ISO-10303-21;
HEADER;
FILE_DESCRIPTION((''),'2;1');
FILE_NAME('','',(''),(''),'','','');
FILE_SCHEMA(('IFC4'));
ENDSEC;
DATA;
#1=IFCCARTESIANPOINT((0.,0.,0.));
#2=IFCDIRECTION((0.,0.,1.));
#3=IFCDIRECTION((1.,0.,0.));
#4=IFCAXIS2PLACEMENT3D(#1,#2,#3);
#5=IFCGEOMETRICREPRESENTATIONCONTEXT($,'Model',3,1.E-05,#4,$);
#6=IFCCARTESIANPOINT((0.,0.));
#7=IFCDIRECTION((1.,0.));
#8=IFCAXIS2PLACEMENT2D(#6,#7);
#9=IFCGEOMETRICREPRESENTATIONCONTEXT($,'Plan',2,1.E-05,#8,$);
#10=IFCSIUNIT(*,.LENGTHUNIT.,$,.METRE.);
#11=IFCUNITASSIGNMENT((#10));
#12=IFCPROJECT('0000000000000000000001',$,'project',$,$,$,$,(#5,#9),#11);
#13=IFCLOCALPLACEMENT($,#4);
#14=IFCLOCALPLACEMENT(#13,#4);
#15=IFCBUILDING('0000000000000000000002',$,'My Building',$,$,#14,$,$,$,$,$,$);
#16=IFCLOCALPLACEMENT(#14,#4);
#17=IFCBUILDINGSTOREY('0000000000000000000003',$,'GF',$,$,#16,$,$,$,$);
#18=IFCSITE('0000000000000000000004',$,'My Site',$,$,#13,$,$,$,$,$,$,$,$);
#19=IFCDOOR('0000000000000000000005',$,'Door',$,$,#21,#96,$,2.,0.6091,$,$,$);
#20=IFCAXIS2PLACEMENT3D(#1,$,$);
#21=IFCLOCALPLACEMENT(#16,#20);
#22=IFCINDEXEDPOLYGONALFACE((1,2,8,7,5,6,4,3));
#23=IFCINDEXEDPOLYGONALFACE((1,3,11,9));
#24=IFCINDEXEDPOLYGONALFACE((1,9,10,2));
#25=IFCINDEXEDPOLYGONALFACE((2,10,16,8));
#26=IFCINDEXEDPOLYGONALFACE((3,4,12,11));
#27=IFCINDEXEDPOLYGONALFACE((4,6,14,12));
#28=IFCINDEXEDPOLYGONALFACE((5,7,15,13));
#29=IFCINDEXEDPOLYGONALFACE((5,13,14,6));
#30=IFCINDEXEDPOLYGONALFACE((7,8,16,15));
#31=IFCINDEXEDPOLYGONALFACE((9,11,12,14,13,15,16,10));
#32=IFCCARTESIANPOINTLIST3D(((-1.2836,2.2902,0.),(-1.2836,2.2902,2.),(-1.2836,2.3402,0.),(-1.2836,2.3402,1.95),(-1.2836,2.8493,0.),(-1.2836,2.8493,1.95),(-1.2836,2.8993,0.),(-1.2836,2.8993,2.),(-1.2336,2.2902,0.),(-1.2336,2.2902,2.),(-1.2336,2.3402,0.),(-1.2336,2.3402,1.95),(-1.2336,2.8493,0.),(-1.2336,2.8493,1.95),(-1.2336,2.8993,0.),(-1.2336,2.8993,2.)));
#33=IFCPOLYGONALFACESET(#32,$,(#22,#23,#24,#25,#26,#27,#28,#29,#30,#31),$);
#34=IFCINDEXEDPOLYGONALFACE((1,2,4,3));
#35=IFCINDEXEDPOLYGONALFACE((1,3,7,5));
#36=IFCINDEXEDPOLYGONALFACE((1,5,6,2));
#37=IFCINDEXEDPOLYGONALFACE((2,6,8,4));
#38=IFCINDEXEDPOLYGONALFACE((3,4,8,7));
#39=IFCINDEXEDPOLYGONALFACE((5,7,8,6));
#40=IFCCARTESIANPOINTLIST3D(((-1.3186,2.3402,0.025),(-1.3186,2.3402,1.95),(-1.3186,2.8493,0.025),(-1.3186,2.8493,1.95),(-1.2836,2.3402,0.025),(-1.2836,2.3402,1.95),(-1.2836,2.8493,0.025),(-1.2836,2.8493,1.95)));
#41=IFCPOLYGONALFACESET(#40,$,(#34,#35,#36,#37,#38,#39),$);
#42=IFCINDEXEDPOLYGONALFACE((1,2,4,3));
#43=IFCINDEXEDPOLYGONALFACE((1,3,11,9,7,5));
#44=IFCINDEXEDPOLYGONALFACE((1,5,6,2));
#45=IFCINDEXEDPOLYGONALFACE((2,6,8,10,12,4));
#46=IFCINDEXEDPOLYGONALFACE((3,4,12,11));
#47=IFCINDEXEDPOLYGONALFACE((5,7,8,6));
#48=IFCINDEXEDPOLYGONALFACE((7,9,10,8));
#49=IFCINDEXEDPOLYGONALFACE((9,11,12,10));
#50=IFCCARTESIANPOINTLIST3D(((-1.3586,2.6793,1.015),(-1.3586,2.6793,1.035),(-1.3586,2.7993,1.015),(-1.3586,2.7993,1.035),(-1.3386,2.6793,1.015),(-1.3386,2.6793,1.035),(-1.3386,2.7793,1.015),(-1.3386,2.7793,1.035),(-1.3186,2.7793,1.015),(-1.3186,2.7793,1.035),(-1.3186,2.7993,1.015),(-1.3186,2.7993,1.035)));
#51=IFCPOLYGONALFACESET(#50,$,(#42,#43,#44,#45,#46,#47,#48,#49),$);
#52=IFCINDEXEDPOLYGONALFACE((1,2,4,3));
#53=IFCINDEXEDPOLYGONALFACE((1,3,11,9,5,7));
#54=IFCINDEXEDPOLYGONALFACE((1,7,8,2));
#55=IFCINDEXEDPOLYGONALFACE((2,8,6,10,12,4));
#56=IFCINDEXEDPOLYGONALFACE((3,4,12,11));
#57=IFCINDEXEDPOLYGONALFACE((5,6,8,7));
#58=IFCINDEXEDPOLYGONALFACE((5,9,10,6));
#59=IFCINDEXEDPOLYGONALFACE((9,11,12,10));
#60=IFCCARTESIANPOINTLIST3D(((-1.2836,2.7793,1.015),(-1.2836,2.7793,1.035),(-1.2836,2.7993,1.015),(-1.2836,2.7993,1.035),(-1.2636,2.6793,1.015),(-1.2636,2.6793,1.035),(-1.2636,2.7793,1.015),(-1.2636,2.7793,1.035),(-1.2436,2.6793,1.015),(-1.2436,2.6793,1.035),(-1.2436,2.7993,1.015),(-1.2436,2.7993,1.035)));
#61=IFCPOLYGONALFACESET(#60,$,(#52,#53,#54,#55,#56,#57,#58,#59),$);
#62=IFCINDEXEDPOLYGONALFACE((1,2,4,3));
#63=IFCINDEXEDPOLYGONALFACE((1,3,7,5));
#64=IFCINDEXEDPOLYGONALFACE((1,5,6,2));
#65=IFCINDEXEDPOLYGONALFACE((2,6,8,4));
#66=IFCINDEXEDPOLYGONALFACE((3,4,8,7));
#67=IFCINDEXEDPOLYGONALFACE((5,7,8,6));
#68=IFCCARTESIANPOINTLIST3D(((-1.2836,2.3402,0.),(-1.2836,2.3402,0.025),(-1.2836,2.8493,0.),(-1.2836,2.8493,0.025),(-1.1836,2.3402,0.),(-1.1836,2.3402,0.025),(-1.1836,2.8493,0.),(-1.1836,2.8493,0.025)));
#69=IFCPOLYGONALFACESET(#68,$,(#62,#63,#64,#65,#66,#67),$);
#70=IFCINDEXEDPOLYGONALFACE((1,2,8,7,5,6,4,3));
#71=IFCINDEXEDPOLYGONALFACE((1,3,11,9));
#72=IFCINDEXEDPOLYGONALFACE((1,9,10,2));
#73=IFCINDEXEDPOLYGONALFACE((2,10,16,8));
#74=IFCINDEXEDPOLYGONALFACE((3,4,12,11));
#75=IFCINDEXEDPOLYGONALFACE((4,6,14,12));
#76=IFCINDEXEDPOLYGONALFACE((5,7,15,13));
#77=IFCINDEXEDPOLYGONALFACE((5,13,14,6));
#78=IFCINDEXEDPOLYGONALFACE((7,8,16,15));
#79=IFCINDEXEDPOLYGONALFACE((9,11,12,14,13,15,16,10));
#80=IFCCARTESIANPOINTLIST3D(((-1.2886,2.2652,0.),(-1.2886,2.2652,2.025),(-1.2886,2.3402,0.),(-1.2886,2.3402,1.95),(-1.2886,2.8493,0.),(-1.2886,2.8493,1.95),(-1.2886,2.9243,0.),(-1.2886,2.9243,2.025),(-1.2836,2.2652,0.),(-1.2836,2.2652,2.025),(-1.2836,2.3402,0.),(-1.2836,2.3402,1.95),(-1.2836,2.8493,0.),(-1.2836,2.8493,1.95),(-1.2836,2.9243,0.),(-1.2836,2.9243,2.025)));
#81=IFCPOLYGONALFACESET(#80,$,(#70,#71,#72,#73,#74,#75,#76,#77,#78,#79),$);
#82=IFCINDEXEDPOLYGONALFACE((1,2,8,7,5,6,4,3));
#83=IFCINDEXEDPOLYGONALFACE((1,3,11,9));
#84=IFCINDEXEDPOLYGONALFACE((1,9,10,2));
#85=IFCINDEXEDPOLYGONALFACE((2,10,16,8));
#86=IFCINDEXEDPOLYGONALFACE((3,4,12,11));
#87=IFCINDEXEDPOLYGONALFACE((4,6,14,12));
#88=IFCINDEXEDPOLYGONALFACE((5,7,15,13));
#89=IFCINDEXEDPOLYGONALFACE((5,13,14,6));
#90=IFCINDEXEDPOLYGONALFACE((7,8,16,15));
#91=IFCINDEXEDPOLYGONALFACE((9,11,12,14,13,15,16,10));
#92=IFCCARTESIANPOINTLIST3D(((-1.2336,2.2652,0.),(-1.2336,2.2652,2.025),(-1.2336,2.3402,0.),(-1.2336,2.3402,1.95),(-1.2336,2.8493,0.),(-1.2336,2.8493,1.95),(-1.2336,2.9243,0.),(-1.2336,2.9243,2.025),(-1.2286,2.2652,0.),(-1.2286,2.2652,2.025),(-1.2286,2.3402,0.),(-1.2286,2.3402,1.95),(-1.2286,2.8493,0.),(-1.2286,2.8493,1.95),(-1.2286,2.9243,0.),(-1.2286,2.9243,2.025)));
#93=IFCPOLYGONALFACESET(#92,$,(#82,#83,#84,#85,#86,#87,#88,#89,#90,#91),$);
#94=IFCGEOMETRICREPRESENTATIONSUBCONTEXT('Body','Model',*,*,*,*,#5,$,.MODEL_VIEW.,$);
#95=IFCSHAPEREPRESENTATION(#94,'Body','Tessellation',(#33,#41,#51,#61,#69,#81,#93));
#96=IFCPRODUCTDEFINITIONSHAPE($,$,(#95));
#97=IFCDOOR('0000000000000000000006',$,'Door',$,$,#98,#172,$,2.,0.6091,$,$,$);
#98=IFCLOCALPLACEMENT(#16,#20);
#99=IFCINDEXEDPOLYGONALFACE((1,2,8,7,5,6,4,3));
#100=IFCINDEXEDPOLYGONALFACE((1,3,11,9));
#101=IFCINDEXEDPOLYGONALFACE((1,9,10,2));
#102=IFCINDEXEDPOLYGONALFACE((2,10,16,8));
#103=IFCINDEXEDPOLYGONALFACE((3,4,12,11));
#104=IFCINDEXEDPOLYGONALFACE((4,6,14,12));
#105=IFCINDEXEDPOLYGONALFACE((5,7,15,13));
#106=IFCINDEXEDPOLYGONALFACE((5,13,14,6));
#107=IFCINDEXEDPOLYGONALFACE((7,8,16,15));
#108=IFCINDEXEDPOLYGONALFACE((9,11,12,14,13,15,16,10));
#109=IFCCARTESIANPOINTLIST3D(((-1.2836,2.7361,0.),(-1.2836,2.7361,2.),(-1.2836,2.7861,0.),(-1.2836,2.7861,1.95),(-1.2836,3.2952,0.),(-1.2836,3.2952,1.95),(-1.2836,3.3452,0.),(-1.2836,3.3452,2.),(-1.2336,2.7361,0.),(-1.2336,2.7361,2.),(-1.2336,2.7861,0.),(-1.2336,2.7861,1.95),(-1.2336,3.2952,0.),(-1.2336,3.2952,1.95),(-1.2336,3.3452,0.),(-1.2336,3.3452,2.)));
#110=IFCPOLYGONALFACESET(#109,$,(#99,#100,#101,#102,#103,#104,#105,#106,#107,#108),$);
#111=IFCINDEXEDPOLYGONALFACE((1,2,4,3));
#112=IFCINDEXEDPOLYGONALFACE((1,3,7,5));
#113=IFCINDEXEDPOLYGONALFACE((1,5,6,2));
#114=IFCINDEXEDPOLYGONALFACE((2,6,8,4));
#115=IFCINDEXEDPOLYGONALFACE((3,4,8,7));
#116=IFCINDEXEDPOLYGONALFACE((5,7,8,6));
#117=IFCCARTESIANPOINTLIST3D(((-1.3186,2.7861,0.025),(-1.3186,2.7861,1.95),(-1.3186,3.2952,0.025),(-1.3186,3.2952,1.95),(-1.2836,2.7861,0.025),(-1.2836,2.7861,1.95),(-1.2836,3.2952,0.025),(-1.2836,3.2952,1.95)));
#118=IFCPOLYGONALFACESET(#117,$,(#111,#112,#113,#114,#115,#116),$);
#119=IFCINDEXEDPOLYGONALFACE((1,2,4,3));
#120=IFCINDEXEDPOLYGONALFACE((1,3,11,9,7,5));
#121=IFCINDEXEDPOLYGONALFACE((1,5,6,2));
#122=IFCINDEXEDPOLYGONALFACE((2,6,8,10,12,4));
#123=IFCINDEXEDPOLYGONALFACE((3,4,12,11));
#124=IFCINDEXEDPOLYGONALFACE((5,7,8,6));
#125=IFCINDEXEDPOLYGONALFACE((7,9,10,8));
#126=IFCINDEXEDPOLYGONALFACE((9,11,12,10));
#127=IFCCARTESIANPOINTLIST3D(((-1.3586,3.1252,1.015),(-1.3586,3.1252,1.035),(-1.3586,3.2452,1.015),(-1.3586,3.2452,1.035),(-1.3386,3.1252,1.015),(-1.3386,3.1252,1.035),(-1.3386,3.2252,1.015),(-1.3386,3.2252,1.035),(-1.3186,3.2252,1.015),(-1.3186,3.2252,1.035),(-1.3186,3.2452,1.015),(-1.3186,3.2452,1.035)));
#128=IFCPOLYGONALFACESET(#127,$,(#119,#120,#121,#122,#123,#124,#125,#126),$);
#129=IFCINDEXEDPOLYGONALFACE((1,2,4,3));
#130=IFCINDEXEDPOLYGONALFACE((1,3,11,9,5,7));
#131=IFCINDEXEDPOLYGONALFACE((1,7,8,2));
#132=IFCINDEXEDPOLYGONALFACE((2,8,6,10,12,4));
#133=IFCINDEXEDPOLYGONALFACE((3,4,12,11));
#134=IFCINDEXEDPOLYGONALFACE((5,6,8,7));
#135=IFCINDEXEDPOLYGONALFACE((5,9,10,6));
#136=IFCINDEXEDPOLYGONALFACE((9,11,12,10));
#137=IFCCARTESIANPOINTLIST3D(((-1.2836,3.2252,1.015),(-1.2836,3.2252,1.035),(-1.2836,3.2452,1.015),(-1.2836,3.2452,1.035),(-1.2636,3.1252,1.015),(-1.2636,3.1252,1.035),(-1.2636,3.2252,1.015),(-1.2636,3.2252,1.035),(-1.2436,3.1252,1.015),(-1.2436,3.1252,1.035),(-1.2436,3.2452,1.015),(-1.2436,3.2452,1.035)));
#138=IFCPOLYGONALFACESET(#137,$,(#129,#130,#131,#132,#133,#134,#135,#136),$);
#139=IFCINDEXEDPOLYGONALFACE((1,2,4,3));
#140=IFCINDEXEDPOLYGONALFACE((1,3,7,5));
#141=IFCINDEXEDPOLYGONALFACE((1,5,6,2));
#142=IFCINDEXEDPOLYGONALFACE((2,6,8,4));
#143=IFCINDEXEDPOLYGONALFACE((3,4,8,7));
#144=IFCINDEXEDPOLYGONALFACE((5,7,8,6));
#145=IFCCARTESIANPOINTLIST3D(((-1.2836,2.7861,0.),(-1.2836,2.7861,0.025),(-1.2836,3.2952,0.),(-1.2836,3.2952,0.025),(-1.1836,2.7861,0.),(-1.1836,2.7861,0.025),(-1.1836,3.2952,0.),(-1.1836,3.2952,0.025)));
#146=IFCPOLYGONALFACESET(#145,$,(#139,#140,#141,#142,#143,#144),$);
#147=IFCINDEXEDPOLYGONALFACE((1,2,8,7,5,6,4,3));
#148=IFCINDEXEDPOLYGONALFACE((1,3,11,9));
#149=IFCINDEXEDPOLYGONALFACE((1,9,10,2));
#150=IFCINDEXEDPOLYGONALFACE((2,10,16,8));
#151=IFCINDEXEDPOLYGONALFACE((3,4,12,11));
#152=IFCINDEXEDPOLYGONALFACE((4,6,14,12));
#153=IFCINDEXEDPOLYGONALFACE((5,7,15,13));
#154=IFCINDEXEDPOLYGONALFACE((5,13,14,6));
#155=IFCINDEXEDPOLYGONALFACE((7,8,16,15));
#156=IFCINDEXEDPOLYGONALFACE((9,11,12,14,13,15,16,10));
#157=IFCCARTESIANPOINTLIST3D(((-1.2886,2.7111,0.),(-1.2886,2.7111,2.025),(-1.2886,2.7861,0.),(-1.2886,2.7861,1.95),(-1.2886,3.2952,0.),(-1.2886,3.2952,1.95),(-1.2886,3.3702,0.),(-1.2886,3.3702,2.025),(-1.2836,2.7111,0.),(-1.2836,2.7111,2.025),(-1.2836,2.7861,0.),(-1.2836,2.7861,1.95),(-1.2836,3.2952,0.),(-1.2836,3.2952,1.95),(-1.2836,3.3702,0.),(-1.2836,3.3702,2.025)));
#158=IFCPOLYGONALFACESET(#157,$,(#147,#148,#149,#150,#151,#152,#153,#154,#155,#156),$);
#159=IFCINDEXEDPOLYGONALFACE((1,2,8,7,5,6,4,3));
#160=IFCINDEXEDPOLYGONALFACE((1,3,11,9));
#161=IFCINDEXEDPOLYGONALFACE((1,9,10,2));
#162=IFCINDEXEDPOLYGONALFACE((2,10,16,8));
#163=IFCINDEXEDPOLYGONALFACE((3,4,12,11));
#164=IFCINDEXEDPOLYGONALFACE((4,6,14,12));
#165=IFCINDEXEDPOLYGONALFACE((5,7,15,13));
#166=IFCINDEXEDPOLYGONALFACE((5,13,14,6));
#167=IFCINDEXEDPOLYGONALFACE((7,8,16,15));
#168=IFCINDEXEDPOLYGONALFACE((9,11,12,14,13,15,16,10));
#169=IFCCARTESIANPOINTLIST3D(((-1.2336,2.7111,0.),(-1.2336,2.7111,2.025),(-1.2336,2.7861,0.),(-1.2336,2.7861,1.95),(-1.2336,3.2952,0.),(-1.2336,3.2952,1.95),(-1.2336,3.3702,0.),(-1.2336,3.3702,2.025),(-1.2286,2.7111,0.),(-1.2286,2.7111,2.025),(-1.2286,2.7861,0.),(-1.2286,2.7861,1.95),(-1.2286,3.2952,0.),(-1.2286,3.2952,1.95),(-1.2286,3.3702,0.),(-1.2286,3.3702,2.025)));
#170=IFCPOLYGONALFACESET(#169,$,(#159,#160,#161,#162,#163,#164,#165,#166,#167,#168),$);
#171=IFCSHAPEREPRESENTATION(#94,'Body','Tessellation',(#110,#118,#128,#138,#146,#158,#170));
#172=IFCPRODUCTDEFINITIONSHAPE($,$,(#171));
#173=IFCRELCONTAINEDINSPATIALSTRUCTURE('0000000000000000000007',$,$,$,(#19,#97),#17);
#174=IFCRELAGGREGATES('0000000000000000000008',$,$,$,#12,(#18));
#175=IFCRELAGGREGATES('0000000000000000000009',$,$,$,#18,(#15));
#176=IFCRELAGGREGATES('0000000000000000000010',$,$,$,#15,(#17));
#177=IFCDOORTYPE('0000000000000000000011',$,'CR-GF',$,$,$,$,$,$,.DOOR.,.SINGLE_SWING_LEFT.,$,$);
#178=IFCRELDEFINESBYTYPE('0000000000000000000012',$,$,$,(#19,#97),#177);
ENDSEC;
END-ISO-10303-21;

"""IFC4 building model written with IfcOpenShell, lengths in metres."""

from ifc_helpers import new_model, entity, si_unit, frame, origin_with_axes, origin_2d_with_axis, place, context, subcontext, project, spatial, line, indexed_curve, outline, extrude, shape, source, transform, mapped, type_object, type_shapes, element, save


model = new_model("IFC4")

# Units and contexts
model_context = context("Model", 3, precision=1e-05, world=origin_with_axes())
plan_context = context("Plan", 2, precision=1e-05, world=origin_2d_with_axis())
body_context_1 = subcontext(model_context, "Body", "Model", "MODEL_VIEW")
body_context_2 = subcontext(plan_context, "Body", "Plan", "PLAN_VIEW")
ifc_project = project(units=[si_unit("LENGTHUNIT", "METRE")], contexts=[model_context, plan_context])

# Site, building, storey
site_placement = place(None, origin_with_axes())
site = spatial("IfcSite", under=ifc_project, at=site_placement, Name="My Site")
building_placement = place(site_placement, origin_with_axes())
building = spatial("IfcBuilding", under=site, at=building_placement, Name="My Building")
storey_placement = place(building_placement, origin_with_axes())
storey = spatial("IfcBuildingStorey", under=building, at=storey_placement, Name="GF")

# Shared definitions
wall_1_placement = place(storey_placement, frame((-1.1836, 2.64, 0.0), z_axis=(0.0, 0.0, 1.0), x_axis=(0.0, 1.0, 0.0)))
door_type_1 = type_object("IfcDoorType", Name="CR-GF", OperationType="SINGLE_SWING_LEFT", PredefinedType="DOOR")
shared_shape_1 = source(origin_with_axes(), body_context_1, "Body", "SweptSolid", [
    extrude(outline(indexed_curve([(0.0, 0.0), (0.0, 2.0), (0.6091, 2.0), (0.6091, 0.0), (0.5591, 0.0), (0.5591, 1.95), (0.05, 1.95), (0.05, 0.0)], segments=[line(1, 2, 3, 4, 5, 6, 7, 8, 1)])), frame((0.0, 0.0, 0.0), z_axis=(0.0, -1.0, 0.0), x_axis=(1.0, 0.0, 0.0)), (0.0, 0.0, -1.0), 0.05),
    extrude(outline(indexed_curve([(0.0, 0.0), (0.5091, 0.0), (0.5091, 0.035), (0.0, 0.035)], segments=[line(1, 2, 3, 4, 1)])), frame((0.05, -0.035, 0.025), z_axis=(0.0, 0.0, 1.0), x_axis=(1.0, 0.0, 0.0)), (0.0, 0.0, 1.0), 1.925),
    extrude(outline(indexed_curve([(0.0, 0.0), (0.0, -0.04), (0.12, -0.04), (0.12, -0.02), (0.02, -0.02), (0.02, 0.0)], segments=[line(1, 2, 3, 4, 5, 6, 1)])), frame((0.1, -0.035, 1.015), z_axis=(0.0, 0.0, 1.0), x_axis=(1.0, 0.0, 0.0)), (0.0, 0.0, 1.0), 0.02),
    extrude(outline(indexed_curve([(0.0, 0.0), (0.0, 0.04), (0.12, 0.04), (0.12, 0.02), (0.02, 0.02), (0.02, 0.0)], segments=[line(1, 2, 3, 4, 5, 6, 1)])), frame((0.1, 0.0, 1.015), z_axis=(0.0, 0.0, 1.0), x_axis=(1.0, 0.0, 0.0)), (0.0, 0.0, 1.0), 0.02),
    extrude(outline(indexed_curve([(0.0, 0.0), (0.5091, 0.0), (0.5091, 0.1), (0.0, 0.1)], segments=[line(1, 2, 3, 4, 1)])), frame((0.05, 0.0, 0.0), z_axis=(0.0, 0.0, 1.0), x_axis=(1.0, 0.0, 0.0)), (0.0, 0.0, 1.0), 0.025),
    extrude(outline(indexed_curve([(0.0, 0.0), (0.0, 2.025), (0.6591, 2.025), (0.6591, 0.0), (0.5841, 0.0), (0.5841, 1.95), (0.075, 1.95), (0.075, 0.0)], segments=[line(1, 2, 3, 4, 5, 6, 7, 8, 1)])), frame((-0.025, -0.005, 0.0), z_axis=(0.0, -1.0, 0.0), x_axis=(1.0, 0.0, 0.0)), (0.0, 0.0, -1.0), 0.005),
    extrude(outline(indexed_curve([(0.0, 0.0), (0.0, 2.025), (0.6591, 2.025), (0.6591, 0.0), (0.5841, 0.0), (0.5841, 1.95), (0.075, 1.95), (0.075, 0.0)], segments=[line(1, 2, 3, 4, 5, 6, 7, 8, 1)])), frame((-0.025, 0.05, 0.0), z_axis=(0.0, -1.0, 0.0), x_axis=(1.0, 0.0, 0.0)), (0.0, 0.0, -1.0), 0.005),
])
shared_shape_2 = source(origin_with_axes(), body_context_2, "Body", "Curve2D", [
    entity("IfcIndexedPolyCurve", entity("IfcCartesianPointList2D", [[0.0, 0.0], [0.05, 0.0], [0.05, 0.05], [0.0, 0.05]]), [entity("IfcLineIndex", [1, 2, 3, 4, 1])]),
    entity("IfcIndexedPolyCurve", entity("IfcCartesianPointList2D", [[0.6091, 0.0], [0.5591, 0.0], [0.5591, 0.05], [0.6091, 0.05]]), [entity("IfcLineIndex", [1, 2, 3, 4, 1])]),
    entity("IfcIndexedPolyCurve", entity("IfcCartesianPointList2D", [[0.8137, -0.035], [0.3046, -0.035], [0.3046, 0.0], [0.8137, 0.0]]), [entity("IfcLineIndex", [1, 2, 3, 4, 1])]),
])
type_shapes(door_type_1, [shared_shape_1, shared_shape_2])

# Doors
placement_1 = place(wall_1_placement, frame((0.2593, 0.1, 0.0), z_axis=(0.0, 0.0, 1.0), x_axis=(-1.0, 0.0, 0.0)))
door_1_placement = place(placement_1, frame((0.0, 0.0, 0.0), z_axis=(0.0, 0.0, 1.0), x_axis=(1.0, 0.0, 0.0)))
element("IfcDoor", 1, at=door_1_placement, inside=storey, type_object=door_type_1, Name="Door", OverallHeight=2.0, OverallWidth=0.6091, shapes=[
    shape(body_context_1, "Body", "MappedRepresentation", [mapped(shared_shape_1, transform((0.0, 0.0, 0.0), x_axis=(1.0, 0.0, 0.0), y_axis=(0.0, 1.0, 0.0), z_axis=(0.0, 0.0, 1.0), scale=1.0))]),
    shape(body_context_2, "Body", "MappedRepresentation", [mapped(shared_shape_2, transform((0.0, 0.0, 0.0), x_axis=(1.0, 0.0, 0.0), y_axis=(0.0, 1.0, 0.0), z_axis=(0.0, 0.0, 1.0), scale=1.0))]),
])
placement_2 = place(wall_1_placement, frame((0.7052, 0.1, 0.0), z_axis=(0.0, 0.0, 1.0), x_axis=(-1.0, 0.0, 0.0)))
door_2_placement = place(placement_2, frame((0.0, 0.0, 0.0), z_axis=(0.0, 0.0, 1.0), x_axis=(1.0, 0.0, 0.0)))
element("IfcDoor", 2, at=door_2_placement, inside=storey, type_object=door_type_1, Name="Door", OverallHeight=2.0, OverallWidth=0.6091, shapes=[
    shape(body_context_1, "Body", "MappedRepresentation", [mapped(shared_shape_1, transform((0.0, 0.0, 0.0), x_axis=(1.0, 0.0, 0.0), y_axis=(0.0, 1.0, 0.0), z_axis=(0.0, 0.0, 1.0), scale=1.0))]),
    shape(body_context_2, "Body", "MappedRepresentation", [mapped(shared_shape_2, transform((0.0, 0.0, 0.0), x_axis=(1.0, 0.0, 0.0), y_axis=(0.0, 1.0, 0.0), z_axis=(0.0, 0.0, 1.0), scale=1.0))]),
])

save(model, "model.ifc")
